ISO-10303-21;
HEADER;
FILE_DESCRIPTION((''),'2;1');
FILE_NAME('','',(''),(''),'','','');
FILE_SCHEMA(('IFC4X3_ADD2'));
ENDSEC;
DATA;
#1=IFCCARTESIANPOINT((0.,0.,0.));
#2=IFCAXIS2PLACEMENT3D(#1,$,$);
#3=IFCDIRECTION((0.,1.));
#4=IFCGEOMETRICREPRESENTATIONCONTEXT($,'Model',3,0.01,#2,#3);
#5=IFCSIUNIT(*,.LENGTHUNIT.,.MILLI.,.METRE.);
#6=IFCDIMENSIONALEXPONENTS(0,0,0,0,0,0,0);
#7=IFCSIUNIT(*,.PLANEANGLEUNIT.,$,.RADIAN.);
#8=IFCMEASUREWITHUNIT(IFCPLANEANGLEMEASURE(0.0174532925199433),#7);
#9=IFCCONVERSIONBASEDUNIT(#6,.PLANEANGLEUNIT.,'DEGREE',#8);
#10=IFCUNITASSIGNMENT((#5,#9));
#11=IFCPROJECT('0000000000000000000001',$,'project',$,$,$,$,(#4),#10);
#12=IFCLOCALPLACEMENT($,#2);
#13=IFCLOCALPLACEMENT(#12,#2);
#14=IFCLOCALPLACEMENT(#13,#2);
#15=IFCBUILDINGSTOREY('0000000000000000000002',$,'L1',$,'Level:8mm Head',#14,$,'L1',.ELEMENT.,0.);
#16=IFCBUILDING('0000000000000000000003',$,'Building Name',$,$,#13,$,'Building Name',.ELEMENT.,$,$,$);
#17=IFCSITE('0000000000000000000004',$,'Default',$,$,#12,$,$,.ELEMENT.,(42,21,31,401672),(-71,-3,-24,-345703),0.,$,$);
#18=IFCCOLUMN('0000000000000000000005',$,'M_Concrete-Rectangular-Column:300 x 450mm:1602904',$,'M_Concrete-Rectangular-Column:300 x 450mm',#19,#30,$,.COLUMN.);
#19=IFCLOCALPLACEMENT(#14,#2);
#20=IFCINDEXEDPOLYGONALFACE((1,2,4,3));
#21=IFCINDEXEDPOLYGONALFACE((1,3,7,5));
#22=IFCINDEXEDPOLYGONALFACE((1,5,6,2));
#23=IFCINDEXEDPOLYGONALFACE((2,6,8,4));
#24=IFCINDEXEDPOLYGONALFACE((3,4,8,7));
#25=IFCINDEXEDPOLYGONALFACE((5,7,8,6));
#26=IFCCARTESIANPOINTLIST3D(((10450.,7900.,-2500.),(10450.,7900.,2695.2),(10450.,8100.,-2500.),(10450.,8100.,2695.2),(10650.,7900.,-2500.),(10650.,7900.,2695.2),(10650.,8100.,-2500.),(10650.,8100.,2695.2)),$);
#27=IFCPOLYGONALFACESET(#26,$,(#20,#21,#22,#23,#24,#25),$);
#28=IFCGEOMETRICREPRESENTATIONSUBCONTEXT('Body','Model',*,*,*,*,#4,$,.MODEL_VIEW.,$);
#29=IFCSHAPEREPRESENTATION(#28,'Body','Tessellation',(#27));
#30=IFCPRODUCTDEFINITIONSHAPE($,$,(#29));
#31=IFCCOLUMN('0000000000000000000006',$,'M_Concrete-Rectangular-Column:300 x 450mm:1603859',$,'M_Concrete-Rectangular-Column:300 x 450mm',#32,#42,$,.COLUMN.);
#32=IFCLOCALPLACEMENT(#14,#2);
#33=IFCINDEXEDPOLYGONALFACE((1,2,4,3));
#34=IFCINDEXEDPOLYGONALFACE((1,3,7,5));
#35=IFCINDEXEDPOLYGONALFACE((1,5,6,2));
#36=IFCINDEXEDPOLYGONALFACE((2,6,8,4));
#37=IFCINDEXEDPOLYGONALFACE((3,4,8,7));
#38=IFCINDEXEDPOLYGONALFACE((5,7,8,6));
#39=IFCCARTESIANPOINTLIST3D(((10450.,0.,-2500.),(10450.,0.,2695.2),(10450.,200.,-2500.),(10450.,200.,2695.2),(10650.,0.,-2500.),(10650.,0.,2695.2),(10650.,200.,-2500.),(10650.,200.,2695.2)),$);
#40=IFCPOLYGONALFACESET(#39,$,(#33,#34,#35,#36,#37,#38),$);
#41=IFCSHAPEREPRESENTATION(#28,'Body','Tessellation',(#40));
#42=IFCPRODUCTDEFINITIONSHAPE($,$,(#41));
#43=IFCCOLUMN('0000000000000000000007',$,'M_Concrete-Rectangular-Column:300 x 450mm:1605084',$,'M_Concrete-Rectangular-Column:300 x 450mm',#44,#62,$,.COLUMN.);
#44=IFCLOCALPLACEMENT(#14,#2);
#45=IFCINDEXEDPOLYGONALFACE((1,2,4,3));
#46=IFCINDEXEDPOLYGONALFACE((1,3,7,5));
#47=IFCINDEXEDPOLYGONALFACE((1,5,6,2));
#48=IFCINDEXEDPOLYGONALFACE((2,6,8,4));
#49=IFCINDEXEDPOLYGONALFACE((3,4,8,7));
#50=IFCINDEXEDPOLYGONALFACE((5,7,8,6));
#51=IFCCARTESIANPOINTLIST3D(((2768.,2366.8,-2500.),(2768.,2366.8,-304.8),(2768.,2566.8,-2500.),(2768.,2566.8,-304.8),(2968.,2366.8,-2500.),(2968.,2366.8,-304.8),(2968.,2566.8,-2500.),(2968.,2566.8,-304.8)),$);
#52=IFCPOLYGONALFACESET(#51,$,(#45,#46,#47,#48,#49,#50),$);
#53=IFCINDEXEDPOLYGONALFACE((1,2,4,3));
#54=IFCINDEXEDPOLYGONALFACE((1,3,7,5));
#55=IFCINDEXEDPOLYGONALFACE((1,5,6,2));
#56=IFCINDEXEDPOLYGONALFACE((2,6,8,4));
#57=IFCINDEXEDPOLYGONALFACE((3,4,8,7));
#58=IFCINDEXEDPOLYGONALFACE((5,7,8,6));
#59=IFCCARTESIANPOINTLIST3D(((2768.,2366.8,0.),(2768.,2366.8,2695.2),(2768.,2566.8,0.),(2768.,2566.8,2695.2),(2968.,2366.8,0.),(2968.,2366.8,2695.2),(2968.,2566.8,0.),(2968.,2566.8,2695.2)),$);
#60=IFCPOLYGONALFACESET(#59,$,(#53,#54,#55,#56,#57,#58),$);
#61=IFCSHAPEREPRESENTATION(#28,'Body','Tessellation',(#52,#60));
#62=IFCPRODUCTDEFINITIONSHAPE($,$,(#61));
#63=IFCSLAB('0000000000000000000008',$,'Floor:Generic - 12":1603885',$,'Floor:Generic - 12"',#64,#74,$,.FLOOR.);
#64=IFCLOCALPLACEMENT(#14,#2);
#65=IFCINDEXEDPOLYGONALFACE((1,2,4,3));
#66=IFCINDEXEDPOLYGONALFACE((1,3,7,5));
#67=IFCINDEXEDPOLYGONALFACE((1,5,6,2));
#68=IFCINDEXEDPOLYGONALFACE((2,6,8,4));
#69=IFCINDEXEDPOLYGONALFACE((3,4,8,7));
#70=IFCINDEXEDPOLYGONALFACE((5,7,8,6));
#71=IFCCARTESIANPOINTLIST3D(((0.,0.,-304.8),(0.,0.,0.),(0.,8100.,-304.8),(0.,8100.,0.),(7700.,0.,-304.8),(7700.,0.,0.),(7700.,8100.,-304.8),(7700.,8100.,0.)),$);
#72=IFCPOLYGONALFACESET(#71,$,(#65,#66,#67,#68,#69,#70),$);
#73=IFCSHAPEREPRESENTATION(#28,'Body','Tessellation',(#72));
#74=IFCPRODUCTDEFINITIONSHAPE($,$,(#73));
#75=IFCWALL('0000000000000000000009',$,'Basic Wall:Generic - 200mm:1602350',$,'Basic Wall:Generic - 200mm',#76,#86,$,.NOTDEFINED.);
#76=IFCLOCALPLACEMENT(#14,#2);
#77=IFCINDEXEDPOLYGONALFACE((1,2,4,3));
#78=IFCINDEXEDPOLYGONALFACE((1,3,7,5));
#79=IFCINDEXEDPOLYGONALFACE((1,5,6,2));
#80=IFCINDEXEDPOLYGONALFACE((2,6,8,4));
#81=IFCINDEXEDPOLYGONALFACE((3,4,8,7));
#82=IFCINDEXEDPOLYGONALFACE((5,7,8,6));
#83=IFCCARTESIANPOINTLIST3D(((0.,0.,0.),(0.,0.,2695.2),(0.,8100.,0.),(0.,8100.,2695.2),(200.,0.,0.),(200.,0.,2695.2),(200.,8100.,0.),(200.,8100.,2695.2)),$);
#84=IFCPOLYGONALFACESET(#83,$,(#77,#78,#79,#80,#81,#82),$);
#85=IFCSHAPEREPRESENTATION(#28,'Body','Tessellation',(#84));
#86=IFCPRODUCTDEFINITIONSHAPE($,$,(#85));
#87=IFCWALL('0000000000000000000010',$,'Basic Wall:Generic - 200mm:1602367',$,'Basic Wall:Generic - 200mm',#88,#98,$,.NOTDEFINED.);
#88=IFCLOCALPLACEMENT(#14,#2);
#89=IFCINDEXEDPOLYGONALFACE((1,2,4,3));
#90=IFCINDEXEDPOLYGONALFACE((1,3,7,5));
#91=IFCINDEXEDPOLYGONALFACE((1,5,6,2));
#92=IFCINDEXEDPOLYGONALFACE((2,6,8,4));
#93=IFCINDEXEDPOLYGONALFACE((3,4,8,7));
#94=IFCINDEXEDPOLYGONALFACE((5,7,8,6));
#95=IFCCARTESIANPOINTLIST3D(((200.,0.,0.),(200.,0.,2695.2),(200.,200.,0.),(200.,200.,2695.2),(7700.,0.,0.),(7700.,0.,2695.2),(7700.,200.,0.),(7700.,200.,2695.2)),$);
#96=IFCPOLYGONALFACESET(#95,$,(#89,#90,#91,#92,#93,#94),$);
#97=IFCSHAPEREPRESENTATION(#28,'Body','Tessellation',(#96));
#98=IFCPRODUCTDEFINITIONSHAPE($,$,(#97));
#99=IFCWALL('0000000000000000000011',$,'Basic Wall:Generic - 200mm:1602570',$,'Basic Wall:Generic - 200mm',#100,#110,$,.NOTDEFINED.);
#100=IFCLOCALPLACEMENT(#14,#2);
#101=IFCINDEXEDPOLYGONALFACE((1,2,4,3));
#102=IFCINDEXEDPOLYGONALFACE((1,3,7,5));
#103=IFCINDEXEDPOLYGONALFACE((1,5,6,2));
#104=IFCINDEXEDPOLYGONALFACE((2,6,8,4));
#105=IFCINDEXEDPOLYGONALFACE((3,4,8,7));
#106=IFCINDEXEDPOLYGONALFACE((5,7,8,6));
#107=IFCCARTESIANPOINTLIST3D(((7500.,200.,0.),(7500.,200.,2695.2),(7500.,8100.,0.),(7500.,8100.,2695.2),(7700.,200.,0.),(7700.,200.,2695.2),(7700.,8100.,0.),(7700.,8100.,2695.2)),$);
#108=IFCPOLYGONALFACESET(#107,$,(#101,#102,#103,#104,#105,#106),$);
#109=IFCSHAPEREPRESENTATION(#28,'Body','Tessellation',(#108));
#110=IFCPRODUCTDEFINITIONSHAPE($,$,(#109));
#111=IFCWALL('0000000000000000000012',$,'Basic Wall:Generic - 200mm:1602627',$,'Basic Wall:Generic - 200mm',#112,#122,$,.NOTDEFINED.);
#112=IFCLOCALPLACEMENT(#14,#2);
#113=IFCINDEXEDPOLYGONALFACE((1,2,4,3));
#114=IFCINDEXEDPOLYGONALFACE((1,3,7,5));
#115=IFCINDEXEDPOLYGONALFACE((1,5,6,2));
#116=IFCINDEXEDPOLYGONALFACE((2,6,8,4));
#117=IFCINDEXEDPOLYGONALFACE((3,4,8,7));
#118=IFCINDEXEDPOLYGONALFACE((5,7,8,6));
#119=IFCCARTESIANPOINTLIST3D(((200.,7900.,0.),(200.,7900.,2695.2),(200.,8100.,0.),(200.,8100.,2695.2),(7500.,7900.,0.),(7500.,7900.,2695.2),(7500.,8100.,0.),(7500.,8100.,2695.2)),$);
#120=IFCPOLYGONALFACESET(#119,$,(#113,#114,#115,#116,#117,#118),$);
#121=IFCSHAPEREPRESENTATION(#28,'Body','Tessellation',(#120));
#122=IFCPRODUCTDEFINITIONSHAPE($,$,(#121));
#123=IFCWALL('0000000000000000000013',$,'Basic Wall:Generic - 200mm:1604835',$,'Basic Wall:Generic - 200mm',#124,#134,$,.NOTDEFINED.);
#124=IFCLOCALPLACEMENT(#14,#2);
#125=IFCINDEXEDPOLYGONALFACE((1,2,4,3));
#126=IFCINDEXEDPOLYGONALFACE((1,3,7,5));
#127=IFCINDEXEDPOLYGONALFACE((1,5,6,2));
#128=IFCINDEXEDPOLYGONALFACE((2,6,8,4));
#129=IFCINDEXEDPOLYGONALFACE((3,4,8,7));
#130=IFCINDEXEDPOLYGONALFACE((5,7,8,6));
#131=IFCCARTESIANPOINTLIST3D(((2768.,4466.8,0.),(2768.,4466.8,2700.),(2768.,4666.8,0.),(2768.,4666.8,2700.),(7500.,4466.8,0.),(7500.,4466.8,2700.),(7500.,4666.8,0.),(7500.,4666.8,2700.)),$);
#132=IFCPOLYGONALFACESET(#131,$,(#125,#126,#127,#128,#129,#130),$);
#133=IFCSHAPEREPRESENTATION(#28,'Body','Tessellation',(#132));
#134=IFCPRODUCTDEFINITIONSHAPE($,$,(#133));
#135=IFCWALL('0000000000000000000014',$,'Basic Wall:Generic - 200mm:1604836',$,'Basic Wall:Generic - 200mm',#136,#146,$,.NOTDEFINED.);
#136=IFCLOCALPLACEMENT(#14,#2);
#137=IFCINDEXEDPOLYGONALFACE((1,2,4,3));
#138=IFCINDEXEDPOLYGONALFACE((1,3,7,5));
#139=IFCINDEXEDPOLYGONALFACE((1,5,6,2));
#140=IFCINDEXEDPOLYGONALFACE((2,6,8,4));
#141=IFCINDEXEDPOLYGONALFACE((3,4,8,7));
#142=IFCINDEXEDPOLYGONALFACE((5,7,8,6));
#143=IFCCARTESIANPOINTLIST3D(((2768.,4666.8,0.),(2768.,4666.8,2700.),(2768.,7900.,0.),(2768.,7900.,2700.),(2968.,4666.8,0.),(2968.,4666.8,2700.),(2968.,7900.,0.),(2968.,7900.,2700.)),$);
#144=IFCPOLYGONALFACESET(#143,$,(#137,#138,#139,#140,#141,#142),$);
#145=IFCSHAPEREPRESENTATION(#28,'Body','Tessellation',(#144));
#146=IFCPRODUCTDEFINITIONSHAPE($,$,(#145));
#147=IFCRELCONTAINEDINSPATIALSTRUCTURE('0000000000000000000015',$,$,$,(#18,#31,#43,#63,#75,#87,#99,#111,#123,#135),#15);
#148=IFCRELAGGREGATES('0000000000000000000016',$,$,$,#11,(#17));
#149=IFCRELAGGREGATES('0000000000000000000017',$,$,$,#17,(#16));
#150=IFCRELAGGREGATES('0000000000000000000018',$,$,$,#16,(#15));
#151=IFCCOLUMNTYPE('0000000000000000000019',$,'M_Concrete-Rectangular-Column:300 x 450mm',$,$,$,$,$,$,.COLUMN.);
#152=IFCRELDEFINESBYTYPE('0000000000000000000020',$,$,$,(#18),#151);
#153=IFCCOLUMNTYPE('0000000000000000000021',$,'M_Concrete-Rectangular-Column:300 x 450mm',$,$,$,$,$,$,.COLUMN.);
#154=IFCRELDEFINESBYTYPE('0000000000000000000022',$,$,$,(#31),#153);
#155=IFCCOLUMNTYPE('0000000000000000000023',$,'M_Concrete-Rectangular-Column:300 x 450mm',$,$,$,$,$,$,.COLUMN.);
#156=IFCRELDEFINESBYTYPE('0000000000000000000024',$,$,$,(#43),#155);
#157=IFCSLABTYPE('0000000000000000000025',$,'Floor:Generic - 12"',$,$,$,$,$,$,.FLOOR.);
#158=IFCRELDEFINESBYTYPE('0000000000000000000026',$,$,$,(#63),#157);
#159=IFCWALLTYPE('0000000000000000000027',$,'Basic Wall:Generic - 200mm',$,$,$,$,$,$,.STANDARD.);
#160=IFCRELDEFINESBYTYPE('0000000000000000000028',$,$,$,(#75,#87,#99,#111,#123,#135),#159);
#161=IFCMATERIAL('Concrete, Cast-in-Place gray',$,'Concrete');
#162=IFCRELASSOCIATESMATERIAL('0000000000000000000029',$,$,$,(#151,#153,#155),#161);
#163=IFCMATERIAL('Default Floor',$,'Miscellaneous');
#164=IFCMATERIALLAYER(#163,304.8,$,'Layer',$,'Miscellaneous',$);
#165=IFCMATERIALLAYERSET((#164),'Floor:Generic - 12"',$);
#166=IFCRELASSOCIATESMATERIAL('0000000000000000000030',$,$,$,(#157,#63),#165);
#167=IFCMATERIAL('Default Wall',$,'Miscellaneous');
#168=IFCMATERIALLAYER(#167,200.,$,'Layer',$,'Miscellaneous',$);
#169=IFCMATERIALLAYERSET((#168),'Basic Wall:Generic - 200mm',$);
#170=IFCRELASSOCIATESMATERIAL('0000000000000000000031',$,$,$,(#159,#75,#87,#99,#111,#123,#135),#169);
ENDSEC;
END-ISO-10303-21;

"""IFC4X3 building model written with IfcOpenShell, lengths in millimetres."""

from ifc_helpers import new_model, entity, si_unit, converted_unit, direction, frame, frame_2d, origin, origin_2d_with_axis, place, context, subcontext, project, spatial, polyline, rectangle, extrude, clip, bounded_halfspace, source, transform, mapped, material, layer, layer_set, layer_usage, material_profile, profile_set, type_object, type_shapes, element, save


model = new_model("IFC4X3")

# Units and contexts
model_context = context("Model", 3, precision=0.01, world=origin(), true_north=direction((0.0, 1.0)))
body_context = subcontext(model_context, "Body", "Model", "MODEL_VIEW")
ifc_project = project(units=[si_unit("LENGTHUNIT", "METRE", prefix="MILLI"), converted_unit("PLANEANGLEUNIT", "DEGREE", entity("IfcPlaneAngleMeasure", 0.0174532925199433), si_unit("PLANEANGLEUNIT", "RADIAN"), dimensions=[0, 0, 0, 0, 0, 0, 0])], contexts=[model_context])

# Site, building, storey
site_placement = place(None, origin())
site = spatial("IfcSite", under=ifc_project, at=site_placement, Name="Default", CompositionType="ELEMENT", RefLatitude=(42, 21, 31, 401672), RefLongitude=(-71, -3, -24, -345703), RefElevation=0.0)
building_placement = place(site_placement, origin())
building = spatial("IfcBuilding", under=site, at=building_placement, Name="Building Name", LongName="Building Name", CompositionType="ELEMENT")
storey_placement = place(building_placement, origin())
storey = spatial("IfcBuildingStorey", under=building, at=storey_placement, Name="L1", ObjectType="Level:8mm Head", LongName="L1", CompositionType="ELEMENT", Elevation=0.0)

# Columns
ifc_material_1 = material(Name="Concrete, Cast-in-Place gray", Category="Concrete")
ifc_material_profile = material_profile(ifc_material_1, rectangle(XDim=200.0, YDim=200.0, at=frame_2d((0.0, 0.0), x_axis=(1.0, 0.0))), Name="300 x 450mm")
ifc_profile_set = profile_set([ifc_material_profile], Name="300 x 450mm")
column_type_1 = type_object("IfcColumnType", Name="M_Concrete-Rectangular-Column:300 x 450mm", PredefinedType="COLUMN", material=ifc_profile_set)
shared_shape_1 = source(origin(), body_context, "Body", "SweptSolid", [
    extrude(rectangle(XDim=200.0, YDim=200.0, at=frame_2d((0.0, 0.0), x_axis=(1.0, 0.0))), frame((10550.0, 8000.0, -2500.0), z_axis=(0.0, 0.0, 1.0), x_axis=(-1.0, 0.0, 0.0)), (0.0, 0.0, 1.0), 5195.2),
])
type_shapes(column_type_1, [shared_shape_1])
column_1_placement = place(storey_placement, origin())
element("IfcColumn", 1, at=column_1_placement, inside=storey, type_object=column_type_1, Name="M_Concrete-Rectangular-Column:300 x 450mm:1602904", ObjectType="M_Concrete-Rectangular-Column:300 x 450mm", PredefinedType="COLUMN", context=body_context, shape_type="MappedRepresentation", body=[
    mapped(shared_shape_1, transform((0.0, 0.0, 0.0), scale=1.0)),
])
column_type_2 = type_object("IfcColumnType", Name="M_Concrete-Rectangular-Column:300 x 450mm", PredefinedType="COLUMN", material=ifc_profile_set)
shared_shape_2 = source(origin(), body_context, "Body", "SweptSolid", [
    extrude(rectangle(XDim=200.0, YDim=200.0, at=frame_2d((0.0, 0.0), x_axis=(1.0, 0.0))), frame((10550.0, 100.0, -2500.0), z_axis=(0.0, 0.0, 1.0), x_axis=(-1.0, 0.0, 0.0)), (0.0, 0.0, 1.0), 5195.2),
])
type_shapes(column_type_2, [shared_shape_2])
column_2_placement = place(storey_placement, origin())
element("IfcColumn", 2, at=column_2_placement, inside=storey, type_object=column_type_2, Name="M_Concrete-Rectangular-Column:300 x 450mm:1603859", ObjectType="M_Concrete-Rectangular-Column:300 x 450mm", PredefinedType="COLUMN", context=body_context, shape_type="MappedRepresentation", body=[
    mapped(shared_shape_2, transform((0.0, 0.0, 0.0), scale=1.0)),
])
column_type_3 = type_object("IfcColumnType", Name="M_Concrete-Rectangular-Column:300 x 450mm", PredefinedType="COLUMN", material=ifc_profile_set)
shared_shape_3 = source(origin(), body_context, "Body", "SweptSolid", [
    extrude(rectangle(XDim=200.0, YDim=200.0, at=origin_2d_with_axis()), frame((2868.0, 2466.8, -2500.0), z_axis=(0.0, 0.0, 1.0), x_axis=(-1.0, 0.0, 0.0)), (0.0, 0.0, 1.0), 2195.2),
    extrude(rectangle(XDim=200.0, YDim=200.0, at=origin_2d_with_axis()), frame((2868.0, 2466.8, 0.0), z_axis=(0.0, 0.0, 1.0), x_axis=(-1.0, 0.0, 0.0)), (0.0, 0.0, 1.0), 2695.2),
])
type_shapes(column_type_3, [shared_shape_3])
column_3_placement = place(storey_placement, origin())
element("IfcColumn", 3, at=column_3_placement, inside=storey, type_object=column_type_3, Name="M_Concrete-Rectangular-Column:300 x 450mm:1605084", ObjectType="M_Concrete-Rectangular-Column:300 x 450mm", PredefinedType="COLUMN", context=body_context, shape_type="MappedRepresentation", body=[
    mapped(shared_shape_3, transform((0.0, 0.0, 0.0), scale=1.0)),
])

# Slab
ifc_material_2 = material(Name="Default Floor", Category="Miscellaneous")
ifc_layer_1 = layer(ifc_material_2, 304.8, Name="Layer", Category="Miscellaneous")
ifc_layer_set_1 = layer_set([ifc_layer_1], Name="Floor:Generic - 12\"")
ifc_layer_usage = layer_usage(ifc_layer_set_1, "AXIS3", "POSITIVE", 0.0)
slab_type = type_object("IfcSlabType", Name="Floor:Generic - 12\"", PredefinedType="FLOOR", material=ifc_layer_set_1)
slab_placement = place(storey_placement, origin())
element("IfcSlab", 4, at=slab_placement, inside=storey, type_object=slab_type, material=ifc_layer_usage, Name="Floor:Generic - 12\":1603885", ObjectType="Floor:Generic - 12\"", PredefinedType="FLOOR", context=body_context, shape_type="SweptSolid", body=[
    extrude(rectangle(XDim=8100.0, YDim=7700.0, at=origin_2d_with_axis()), frame((3850.0, 4050.0, 0.0), z_axis=(0.0, 0.0, -1.0), x_axis=(0.0, 1.0, 0.0)), (0.0, 0.0, 1.0), 304.8),
])

# Walls
ifc_material_3 = material(Name="Default Wall", Category="Miscellaneous")
ifc_layer_2 = layer(ifc_material_3, 200.0, Name="Layer", Category="Miscellaneous")
ifc_layer_set_2 = layer_set([ifc_layer_2], Name="Basic Wall:Generic - 200mm")
wall_type = type_object("IfcWallType", Name="Basic Wall:Generic - 200mm", PredefinedType="STANDARD", material=ifc_layer_set_2)
wall_1_placement = place(storey_placement, frame((100.0, 8100.0, 0.0), z_axis=(0.0, 0.0, 1.0), x_axis=(0.0, -1.0, 0.0)))
element("IfcWall", 5, at=wall_1_placement, inside=storey, type_object=wall_type, material=ifc_layer_set_2, Name="Basic Wall:Generic - 200mm:1602350", ObjectType="Basic Wall:Generic - 200mm", PredefinedType="NOTDEFINED", context=body_context, shape_type="Clipping", body=[
    clip(extrude(rectangle(XDim=8100.0, YDim=200.0, at=frame_2d((4050.0, 0.0), x_axis=(-1.0, 0.0))), origin(), (0.0, 0.0, 1.0), 2695.2), bounded_halfspace(frame((0.0, -100.0, 2695.2), z_axis=(0.0, 0.0, -1.0), x_axis=(0.0, 1.0, 0.0)), True, frame((0.0, -100.0, 2695.2)), polyline([(0.0, 0.0), (8100.0, 0.0), (8100.0, 200.0), (7900.0, 200.0), (200.0, 200.0), (0.0, 200.0), (0.0, 0.0)]))),
])
wall_2_placement = place(storey_placement, frame((200.0, 100.0, 0.0)))
element("IfcWall", 6, at=wall_2_placement, inside=storey, type_object=wall_type, material=ifc_layer_set_2, Name="Basic Wall:Generic - 200mm:1602367", ObjectType="Basic Wall:Generic - 200mm", PredefinedType="NOTDEFINED", context=body_context, shape_type="Clipping", body=[
    clip(extrude(rectangle(XDim=7500.0, YDim=200.0, at=frame_2d((3750.0, 0.0), x_axis=(-1.0, 0.0))), origin(), (0.0, 0.0, 1.0), 2695.2), bounded_halfspace(frame((0.0, -100.0, 2695.2), z_axis=(0.0, 0.0, -1.0), x_axis=(1.0, 0.0, 0.0)), True, frame((0.0, -100.0, 2695.2)), polyline([(0.0, 0.0), (7500.0, 0.0), (7500.0, 200.0), (7300.0, 200.0), (0.0, 200.0), (0.0, 0.0)]))),
])
wall_3_placement = place(storey_placement, frame((7600.0, 200.0, 0.0), z_axis=(0.0, 0.0, 1.0), x_axis=(0.0, 1.0, 0.0)))
element("IfcWall", 7, at=wall_3_placement, inside=storey, type_object=wall_type, material=ifc_layer_set_2, Name="Basic Wall:Generic - 200mm:1602570", ObjectType="Basic Wall:Generic - 200mm", PredefinedType="NOTDEFINED", context=body_context, shape_type="Clipping", body=[
    clip(extrude(rectangle(XDim=7900.0, YDim=200.0, at=frame_2d((3950.0, 0.0), x_axis=(-1.0, 0.0))), origin(), (0.0, 0.0, 1.0), 2695.2), bounded_halfspace(frame((0.0, -100.0, 2695.2), z_axis=(0.0, 0.0, -1.0), x_axis=(0.0, -1.0, 0.0)), True, frame((0.0, -100.0, 2695.2)), polyline([(0.0, 0.0), (7900.0, 0.0), (7900.0, 200.0), (7700.0, 200.0), (0.0, 200.0), (0.0, 0.0)]))),
])
wall_4_placement = place(storey_placement, frame((7500.0, 8000.0, 0.0), z_axis=(0.0, 0.0, 1.0), x_axis=(-1.0, 0.0, 0.0)))
element("IfcWall", 8, at=wall_4_placement, inside=storey, type_object=wall_type, material=ifc_layer_set_2, Name="Basic Wall:Generic - 200mm:1602627", ObjectType="Basic Wall:Generic - 200mm", PredefinedType="NOTDEFINED", context=body_context, shape_type="Clipping", body=[
    clip(extrude(rectangle(XDim=7300.0, YDim=200.0, at=frame_2d((3650.0, 0.0), x_axis=(-1.0, 0.0))), origin(), (0.0, 0.0, 1.0), 2695.2), bounded_halfspace(frame((0.0, -100.0, 2695.2), z_axis=(0.0, 0.0, -1.0), x_axis=(-1.0, 0.0, 0.0)), True, frame((0.0, -100.0, 2695.2)), polyline([(0.0, 0.0), (7300.0, 0.0), (7300.0, 200.0), (0.0, 200.0), (0.0, 0.0)]))),
])
wall_5_placement = place(storey_placement, frame((7500.0, 4566.8, 0.0), z_axis=(0.0, 0.0, 1.0), x_axis=(-1.0, 0.0, 0.0)))
element("IfcWall", 9, at=wall_5_placement, inside=storey, type_object=wall_type, material=ifc_layer_set_2, Name="Basic Wall:Generic - 200mm:1604835", ObjectType="Basic Wall:Generic - 200mm", PredefinedType="NOTDEFINED", context=body_context, shape_type="SweptSolid", body=[
    extrude(rectangle(XDim=4732.0, YDim=200.0, at=frame_2d((2366.0, 0.0), x_axis=(-1.0, 0.0))), origin(), (0.0, 0.0, 1.0), 2700.0),
])
wall_6_placement = place(storey_placement, frame((2868.0, 4666.8, 0.0), z_axis=(0.0, 0.0, 1.0), x_axis=(0.0, 1.0, 0.0)))
element("IfcWall", 10, at=wall_6_placement, inside=storey, type_object=wall_type, material=ifc_layer_set_2, Name="Basic Wall:Generic - 200mm:1604836", ObjectType="Basic Wall:Generic - 200mm", PredefinedType="NOTDEFINED", context=body_context, shape_type="SweptSolid", body=[
    extrude(rectangle(XDim=3233.2, YDim=200.0, at=frame_2d((1616.6, 0.0), x_axis=(-1.0, 0.0))), origin(), (0.0, 0.0, 1.0), 2700.0),
])

save(model, "model.ifc")
